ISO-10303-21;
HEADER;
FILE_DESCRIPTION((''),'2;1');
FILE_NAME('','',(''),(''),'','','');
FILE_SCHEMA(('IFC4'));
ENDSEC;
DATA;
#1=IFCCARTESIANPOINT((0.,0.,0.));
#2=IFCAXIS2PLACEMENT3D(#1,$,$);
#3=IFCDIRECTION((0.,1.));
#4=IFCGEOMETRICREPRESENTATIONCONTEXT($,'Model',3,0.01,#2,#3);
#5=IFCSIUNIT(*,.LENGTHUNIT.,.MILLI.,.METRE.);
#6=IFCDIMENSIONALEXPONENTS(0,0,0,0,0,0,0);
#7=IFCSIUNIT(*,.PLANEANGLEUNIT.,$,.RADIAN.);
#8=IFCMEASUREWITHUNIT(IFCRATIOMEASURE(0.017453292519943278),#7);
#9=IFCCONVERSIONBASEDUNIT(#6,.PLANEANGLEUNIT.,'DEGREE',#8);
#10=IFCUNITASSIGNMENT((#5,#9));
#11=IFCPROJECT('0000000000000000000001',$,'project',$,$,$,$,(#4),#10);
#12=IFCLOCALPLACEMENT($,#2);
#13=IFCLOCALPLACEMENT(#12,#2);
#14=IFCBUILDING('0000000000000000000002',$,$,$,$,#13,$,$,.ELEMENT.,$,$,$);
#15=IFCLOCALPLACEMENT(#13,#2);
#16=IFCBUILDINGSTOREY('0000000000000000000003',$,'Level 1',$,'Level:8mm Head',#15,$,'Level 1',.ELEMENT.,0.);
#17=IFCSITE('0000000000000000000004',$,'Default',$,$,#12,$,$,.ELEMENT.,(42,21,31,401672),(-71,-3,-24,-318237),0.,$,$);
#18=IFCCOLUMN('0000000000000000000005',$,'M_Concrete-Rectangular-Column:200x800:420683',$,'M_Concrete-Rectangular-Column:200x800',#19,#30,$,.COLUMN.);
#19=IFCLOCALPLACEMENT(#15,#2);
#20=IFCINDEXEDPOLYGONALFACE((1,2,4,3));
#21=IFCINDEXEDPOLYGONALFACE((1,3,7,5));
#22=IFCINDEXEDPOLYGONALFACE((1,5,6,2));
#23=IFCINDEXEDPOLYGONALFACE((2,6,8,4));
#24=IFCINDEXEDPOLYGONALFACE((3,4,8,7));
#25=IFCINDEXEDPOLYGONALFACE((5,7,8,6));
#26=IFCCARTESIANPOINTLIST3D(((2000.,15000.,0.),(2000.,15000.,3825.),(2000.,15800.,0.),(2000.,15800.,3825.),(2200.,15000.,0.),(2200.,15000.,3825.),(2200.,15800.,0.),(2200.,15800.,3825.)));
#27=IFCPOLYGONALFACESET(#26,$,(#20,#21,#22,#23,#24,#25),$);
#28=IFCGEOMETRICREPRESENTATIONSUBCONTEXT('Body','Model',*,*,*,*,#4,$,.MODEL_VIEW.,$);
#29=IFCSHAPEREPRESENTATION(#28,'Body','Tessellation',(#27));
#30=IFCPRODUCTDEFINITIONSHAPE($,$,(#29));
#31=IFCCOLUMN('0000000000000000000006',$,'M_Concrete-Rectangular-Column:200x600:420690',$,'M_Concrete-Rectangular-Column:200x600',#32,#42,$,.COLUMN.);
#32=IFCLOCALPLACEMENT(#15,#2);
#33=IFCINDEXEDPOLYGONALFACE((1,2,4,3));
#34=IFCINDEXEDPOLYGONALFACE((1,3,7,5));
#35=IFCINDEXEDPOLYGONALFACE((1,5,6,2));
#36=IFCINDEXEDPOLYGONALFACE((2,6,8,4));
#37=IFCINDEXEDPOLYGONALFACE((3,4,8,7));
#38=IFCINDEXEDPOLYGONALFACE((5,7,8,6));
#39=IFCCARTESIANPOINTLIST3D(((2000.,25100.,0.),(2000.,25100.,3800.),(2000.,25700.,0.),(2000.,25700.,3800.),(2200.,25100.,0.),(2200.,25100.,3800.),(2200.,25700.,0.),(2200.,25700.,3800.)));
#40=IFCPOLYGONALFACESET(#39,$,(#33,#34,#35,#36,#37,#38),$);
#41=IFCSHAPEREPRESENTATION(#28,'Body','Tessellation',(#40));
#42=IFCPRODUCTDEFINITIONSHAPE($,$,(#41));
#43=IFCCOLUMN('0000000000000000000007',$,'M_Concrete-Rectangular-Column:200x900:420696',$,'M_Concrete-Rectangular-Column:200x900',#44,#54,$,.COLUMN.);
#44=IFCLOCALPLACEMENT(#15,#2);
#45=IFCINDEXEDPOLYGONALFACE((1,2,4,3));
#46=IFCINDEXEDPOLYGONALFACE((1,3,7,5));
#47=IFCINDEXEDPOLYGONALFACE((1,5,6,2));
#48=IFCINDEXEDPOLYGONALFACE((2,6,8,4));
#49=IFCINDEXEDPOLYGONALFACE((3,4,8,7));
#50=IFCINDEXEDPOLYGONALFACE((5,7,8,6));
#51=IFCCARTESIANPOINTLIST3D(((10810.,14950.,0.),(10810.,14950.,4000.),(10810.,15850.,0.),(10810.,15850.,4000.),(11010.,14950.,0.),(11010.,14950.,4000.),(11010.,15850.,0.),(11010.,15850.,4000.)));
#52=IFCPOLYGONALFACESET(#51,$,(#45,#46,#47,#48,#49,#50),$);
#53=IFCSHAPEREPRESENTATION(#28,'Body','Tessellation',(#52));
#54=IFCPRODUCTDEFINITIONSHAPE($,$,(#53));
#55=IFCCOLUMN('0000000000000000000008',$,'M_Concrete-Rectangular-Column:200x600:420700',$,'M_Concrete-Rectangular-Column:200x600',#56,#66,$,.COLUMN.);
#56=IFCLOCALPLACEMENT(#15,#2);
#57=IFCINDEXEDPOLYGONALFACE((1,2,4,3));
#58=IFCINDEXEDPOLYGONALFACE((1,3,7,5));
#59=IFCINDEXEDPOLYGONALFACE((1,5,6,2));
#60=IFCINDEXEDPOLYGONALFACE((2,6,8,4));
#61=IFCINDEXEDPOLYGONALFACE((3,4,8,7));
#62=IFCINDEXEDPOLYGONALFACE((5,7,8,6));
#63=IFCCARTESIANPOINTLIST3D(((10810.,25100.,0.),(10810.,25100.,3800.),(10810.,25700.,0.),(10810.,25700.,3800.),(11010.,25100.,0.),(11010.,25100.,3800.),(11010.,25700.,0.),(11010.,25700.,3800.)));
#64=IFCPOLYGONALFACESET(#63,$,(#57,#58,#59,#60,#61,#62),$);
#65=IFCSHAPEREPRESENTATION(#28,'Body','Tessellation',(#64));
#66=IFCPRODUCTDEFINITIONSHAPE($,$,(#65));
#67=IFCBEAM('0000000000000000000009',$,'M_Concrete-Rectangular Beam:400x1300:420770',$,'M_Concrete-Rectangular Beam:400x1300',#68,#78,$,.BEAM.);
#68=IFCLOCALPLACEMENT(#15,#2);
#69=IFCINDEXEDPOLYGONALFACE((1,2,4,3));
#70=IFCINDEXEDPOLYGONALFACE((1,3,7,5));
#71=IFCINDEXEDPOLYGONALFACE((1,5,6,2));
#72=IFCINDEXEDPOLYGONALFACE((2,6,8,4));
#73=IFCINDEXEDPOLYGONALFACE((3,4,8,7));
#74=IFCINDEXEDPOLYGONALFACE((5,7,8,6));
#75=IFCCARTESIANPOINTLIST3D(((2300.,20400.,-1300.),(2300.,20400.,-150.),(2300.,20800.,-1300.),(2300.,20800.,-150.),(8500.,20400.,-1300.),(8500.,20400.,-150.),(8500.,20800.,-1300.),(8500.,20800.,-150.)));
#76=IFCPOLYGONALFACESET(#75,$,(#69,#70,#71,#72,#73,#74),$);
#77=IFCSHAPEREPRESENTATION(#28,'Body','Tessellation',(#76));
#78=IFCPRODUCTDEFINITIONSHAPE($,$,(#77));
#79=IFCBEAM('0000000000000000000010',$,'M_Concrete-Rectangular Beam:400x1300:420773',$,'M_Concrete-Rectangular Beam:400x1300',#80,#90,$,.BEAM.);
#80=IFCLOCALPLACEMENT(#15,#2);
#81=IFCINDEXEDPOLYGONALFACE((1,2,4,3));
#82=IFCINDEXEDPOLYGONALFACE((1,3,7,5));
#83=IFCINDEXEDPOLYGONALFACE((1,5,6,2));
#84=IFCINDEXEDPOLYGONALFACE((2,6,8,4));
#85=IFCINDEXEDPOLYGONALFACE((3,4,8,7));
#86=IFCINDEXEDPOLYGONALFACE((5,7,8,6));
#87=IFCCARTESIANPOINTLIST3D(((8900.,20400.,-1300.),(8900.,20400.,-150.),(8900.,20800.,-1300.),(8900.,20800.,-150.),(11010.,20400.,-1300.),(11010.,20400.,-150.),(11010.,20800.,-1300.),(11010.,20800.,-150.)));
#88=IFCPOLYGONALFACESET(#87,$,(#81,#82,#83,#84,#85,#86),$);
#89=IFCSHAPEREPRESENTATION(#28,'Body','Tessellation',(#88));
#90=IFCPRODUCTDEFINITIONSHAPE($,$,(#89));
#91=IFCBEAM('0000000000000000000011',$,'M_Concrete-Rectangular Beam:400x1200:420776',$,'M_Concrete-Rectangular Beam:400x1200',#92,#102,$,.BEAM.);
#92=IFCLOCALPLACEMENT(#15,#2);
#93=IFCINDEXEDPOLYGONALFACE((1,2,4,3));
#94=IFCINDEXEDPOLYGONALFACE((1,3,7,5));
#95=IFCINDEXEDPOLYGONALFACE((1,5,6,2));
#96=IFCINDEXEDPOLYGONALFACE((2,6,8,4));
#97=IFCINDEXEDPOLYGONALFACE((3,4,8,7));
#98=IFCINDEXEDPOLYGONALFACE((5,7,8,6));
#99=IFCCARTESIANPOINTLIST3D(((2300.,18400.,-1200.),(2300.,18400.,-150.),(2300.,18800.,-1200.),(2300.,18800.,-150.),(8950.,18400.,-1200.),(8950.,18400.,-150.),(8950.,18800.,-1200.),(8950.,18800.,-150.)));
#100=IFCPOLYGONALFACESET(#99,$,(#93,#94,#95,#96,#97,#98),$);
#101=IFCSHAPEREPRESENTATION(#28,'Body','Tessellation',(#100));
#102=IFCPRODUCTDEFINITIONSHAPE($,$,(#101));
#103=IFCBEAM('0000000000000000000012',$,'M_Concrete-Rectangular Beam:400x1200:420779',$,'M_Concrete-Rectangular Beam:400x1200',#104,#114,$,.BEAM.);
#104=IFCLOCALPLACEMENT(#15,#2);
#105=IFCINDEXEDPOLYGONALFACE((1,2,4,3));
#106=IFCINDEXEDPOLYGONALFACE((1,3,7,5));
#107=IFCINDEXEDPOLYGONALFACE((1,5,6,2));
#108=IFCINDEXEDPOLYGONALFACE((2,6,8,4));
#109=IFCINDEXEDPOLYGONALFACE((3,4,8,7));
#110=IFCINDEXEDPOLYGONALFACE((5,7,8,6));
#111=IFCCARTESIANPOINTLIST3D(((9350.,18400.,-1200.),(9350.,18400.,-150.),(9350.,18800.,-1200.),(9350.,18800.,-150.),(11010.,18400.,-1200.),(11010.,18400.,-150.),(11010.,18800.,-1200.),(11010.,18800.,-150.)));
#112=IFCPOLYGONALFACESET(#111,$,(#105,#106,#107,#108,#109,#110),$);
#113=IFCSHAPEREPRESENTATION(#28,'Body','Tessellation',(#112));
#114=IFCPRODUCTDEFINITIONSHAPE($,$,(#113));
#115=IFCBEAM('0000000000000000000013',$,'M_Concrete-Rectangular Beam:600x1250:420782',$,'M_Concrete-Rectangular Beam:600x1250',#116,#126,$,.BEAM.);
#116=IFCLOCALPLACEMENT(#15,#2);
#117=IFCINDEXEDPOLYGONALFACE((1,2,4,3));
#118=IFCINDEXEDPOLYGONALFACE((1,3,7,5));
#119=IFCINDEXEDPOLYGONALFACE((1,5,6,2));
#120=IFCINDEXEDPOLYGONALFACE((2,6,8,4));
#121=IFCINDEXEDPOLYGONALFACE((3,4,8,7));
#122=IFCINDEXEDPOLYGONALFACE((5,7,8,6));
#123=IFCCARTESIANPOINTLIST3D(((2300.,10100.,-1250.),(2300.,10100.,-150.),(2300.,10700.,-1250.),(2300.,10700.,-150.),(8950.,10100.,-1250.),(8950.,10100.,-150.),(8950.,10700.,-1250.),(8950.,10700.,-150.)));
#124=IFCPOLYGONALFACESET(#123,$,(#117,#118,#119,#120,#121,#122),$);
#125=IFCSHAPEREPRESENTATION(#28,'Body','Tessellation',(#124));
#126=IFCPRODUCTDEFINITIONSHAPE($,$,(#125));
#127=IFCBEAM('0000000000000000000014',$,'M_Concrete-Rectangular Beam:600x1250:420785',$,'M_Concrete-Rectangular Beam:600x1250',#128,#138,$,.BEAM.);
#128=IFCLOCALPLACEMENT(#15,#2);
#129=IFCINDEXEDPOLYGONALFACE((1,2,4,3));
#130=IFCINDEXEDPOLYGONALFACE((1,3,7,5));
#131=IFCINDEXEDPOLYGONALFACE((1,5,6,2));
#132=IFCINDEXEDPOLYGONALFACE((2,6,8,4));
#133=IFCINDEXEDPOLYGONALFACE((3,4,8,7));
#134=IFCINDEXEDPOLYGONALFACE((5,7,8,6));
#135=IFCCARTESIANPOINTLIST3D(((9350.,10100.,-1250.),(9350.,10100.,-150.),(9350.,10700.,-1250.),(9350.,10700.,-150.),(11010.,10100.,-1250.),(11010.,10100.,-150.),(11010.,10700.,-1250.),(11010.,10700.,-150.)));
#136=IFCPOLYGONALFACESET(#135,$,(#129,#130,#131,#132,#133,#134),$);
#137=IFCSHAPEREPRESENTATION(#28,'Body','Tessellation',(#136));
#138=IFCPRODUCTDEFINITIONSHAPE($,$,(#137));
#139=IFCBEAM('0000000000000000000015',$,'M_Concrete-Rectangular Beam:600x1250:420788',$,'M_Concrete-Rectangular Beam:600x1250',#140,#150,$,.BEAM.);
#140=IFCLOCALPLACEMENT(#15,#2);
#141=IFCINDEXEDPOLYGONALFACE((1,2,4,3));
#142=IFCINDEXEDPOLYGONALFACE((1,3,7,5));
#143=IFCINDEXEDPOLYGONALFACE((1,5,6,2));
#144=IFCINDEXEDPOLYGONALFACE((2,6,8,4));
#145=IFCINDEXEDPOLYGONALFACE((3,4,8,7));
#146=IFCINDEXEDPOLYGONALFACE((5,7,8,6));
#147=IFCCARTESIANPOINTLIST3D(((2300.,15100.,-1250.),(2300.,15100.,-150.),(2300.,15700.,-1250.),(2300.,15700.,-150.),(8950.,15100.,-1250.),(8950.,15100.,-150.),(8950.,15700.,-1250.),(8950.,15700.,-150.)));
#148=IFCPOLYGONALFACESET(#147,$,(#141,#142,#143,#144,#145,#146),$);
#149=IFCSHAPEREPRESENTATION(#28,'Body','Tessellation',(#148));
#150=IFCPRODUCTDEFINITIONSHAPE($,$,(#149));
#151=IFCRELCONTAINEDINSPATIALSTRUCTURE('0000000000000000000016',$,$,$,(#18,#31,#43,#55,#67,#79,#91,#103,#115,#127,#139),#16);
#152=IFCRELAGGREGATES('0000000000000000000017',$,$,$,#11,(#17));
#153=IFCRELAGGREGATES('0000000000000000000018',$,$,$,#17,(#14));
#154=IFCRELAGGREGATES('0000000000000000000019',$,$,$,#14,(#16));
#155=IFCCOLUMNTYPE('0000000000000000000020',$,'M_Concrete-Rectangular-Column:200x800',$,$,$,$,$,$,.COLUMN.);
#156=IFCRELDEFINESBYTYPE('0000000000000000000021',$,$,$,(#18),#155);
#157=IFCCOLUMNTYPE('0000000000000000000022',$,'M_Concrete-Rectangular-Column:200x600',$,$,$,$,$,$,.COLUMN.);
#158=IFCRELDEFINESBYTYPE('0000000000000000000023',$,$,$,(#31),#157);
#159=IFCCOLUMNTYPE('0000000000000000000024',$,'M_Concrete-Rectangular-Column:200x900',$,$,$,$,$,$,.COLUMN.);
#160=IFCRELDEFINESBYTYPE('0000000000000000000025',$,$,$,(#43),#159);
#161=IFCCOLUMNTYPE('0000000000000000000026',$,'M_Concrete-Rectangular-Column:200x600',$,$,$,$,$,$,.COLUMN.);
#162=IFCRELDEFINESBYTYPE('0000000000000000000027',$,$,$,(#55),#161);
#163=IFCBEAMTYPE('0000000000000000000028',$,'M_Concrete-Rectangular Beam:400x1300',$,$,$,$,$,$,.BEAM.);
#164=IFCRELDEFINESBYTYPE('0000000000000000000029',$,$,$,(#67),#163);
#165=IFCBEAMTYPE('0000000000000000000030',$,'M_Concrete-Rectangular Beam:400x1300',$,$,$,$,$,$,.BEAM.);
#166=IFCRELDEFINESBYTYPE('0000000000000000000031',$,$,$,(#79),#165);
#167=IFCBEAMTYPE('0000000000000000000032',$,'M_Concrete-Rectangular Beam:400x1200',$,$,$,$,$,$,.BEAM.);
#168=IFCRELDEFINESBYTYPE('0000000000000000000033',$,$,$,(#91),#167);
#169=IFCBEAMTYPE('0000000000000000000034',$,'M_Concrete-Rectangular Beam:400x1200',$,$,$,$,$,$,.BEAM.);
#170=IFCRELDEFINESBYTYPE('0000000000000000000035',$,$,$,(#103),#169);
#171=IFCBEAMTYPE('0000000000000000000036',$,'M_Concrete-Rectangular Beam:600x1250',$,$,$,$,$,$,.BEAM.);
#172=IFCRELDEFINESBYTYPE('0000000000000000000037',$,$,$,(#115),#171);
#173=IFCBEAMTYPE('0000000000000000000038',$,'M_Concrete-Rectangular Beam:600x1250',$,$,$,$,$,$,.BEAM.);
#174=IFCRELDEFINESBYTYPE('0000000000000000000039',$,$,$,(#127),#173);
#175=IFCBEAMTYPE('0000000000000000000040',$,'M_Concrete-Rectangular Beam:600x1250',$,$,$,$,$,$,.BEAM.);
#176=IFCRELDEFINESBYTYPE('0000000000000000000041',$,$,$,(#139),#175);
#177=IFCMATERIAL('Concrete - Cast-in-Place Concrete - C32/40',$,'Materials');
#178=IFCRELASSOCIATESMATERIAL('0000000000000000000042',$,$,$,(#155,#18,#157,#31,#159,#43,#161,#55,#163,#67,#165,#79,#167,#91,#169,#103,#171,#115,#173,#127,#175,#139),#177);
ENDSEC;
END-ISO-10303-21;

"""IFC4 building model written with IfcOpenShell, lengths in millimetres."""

from ifc_helpers import new_model, entity, si_unit, converted_unit, direction, frame, origin, place, context, subcontext, project, spatial, indexed_curve, outline, extrude, source, transform, mapped, material, type_object, type_shapes, element, save


model = new_model("IFC4")

# Units and contexts
model_context = context("Model", 3, precision=0.01, world=origin(), true_north=direction((0.0, 1.0)))
body_context = subcontext(model_context, "Body", "Model", "MODEL_VIEW")
ifc_project = project(units=[si_unit("LENGTHUNIT", "METRE", prefix="MILLI"), converted_unit("PLANEANGLEUNIT", "DEGREE", entity("IfcRatioMeasure", 0.017453292519943278), si_unit("PLANEANGLEUNIT", "RADIAN"), dimensions=[0, 0, 0, 0, 0, 0, 0])], contexts=[model_context])

# Site, building, storey
site_placement = place(None, origin())
site = spatial("IfcSite", under=ifc_project, at=site_placement, Name="Default", CompositionType="ELEMENT", RefLatitude=(42, 21, 31, 401672), RefLongitude=(-71, -3, -24, -318237), RefElevation=0.0)
building_placement = place(site_placement, origin())
building = spatial("IfcBuilding", under=site, at=building_placement, CompositionType="ELEMENT")
storey_placement = place(building_placement, origin())
storey = spatial("IfcBuildingStorey", under=building, at=storey_placement, Name="Level 1", ObjectType="Level:8mm Head", LongName="Level 1", CompositionType="ELEMENT", Elevation=0.0)

# Columns
ifc_material = material(Name="Concrete - Cast-in-Place Concrete - C32/40", Category="Materials")
column_type_1 = type_object("IfcColumnType", Name="M_Concrete-Rectangular-Column:200x800", PredefinedType="COLUMN", material=ifc_material)
shared_shape_1 = source(origin(), body_context, "Body", "SweptSolid", [
    extrude(outline(indexed_curve([(-400.0, -100.0), (400.0, -100.0), (400.0, 100.0), (-400.0, 100.0), (-400.0, -100.0)], self_intersect=False)), frame((2100.0, 15400.0, 0.0), z_axis=(0.0, 0.0, 1.0), x_axis=(0.0, -1.0, 0.0)), (0.0, 0.0, 1.0), 3825.0),
])
type_shapes(column_type_1, [shared_shape_1])
column_1_placement = place(storey_placement, origin())
element("IfcColumn", 1, at=column_1_placement, inside=storey, type_object=column_type_1, material=ifc_material, Name="M_Concrete-Rectangular-Column:200x800:420683", ObjectType="M_Concrete-Rectangular-Column:200x800", PredefinedType="COLUMN", context=body_context, shape_type="MappedRepresentation", body=[
    mapped(shared_shape_1, transform((0.0, 0.0, 0.0), scale=1.0)),
])
column_type_2 = type_object("IfcColumnType", Name="M_Concrete-Rectangular-Column:200x600", PredefinedType="COLUMN", material=ifc_material)
shared_shape_2 = source(origin(), body_context, "Body", "SweptSolid", [
    extrude(outline(indexed_curve([(-300.0, -100.0), (300.0, -100.0), (300.0, 100.0), (-300.0, 100.0), (-300.0, -100.0)], self_intersect=False)), frame((2100.0, 25400.0, 0.0), z_axis=(0.0, 0.0, 1.0), x_axis=(0.0, -1.0, 0.0)), (0.0, 0.0, 1.0), 3800.0),
])
type_shapes(column_type_2, [shared_shape_2])
column_2_placement = place(storey_placement, origin())
element("IfcColumn", 2, at=column_2_placement, inside=storey, type_object=column_type_2, material=ifc_material, Name="M_Concrete-Rectangular-Column:200x600:420690", ObjectType="M_Concrete-Rectangular-Column:200x600", PredefinedType="COLUMN", context=body_context, shape_type="MappedRepresentation", body=[
    mapped(shared_shape_2, transform((0.0, 0.0, 0.0), scale=1.0)),
])
column_type_3 = type_object("IfcColumnType", Name="M_Concrete-Rectangular-Column:200x900", PredefinedType="COLUMN", material=ifc_material)
shared_shape_3 = source(origin(), body_context, "Body", "SweptSolid", [
    extrude(outline(indexed_curve([(-450.0, -100.0), (450.0, -100.0), (450.0, 100.0), (-450.0, 100.0), (-450.0, -100.0)], self_intersect=False)), frame((10910.0, 15400.0, 0.0), z_axis=(0.0, 0.0, 1.0), x_axis=(0.0, -1.0, 0.0)), (0.0, 0.0, 1.0), 4000.0),
])
type_shapes(column_type_3, [shared_shape_3])
column_3_placement = place(storey_placement, origin())
element("IfcColumn", 3, at=column_3_placement, inside=storey, type_object=column_type_3, material=ifc_material, Name="M_Concrete-Rectangular-Column:200x900:420696", ObjectType="M_Concrete-Rectangular-Column:200x900", PredefinedType="COLUMN", context=body_context, shape_type="MappedRepresentation", body=[
    mapped(shared_shape_3, transform((0.0, 0.0, 0.0), scale=1.0)),
])
column_type_4 = type_object("IfcColumnType", Name="M_Concrete-Rectangular-Column:200x600", PredefinedType="COLUMN", material=ifc_material)
shared_shape_4 = source(origin(), body_context, "Body", "SweptSolid", [
    extrude(outline(indexed_curve([(-300.0, -100.0), (300.0, -100.0), (300.0, 100.0), (-300.0, 100.0), (-300.0, -100.0)], self_intersect=False)), frame((10910.0, 25400.0, 0.0), z_axis=(0.0, 0.0, 1.0), x_axis=(0.0, -1.0, 0.0)), (0.0, 0.0, 1.0), 3800.0),
])
type_shapes(column_type_4, [shared_shape_4])
column_4_placement = place(storey_placement, origin())
element("IfcColumn", 4, at=column_4_placement, inside=storey, type_object=column_type_4, material=ifc_material, Name="M_Concrete-Rectangular-Column:200x600:420700", ObjectType="M_Concrete-Rectangular-Column:200x600", PredefinedType="COLUMN", context=body_context, shape_type="MappedRepresentation", body=[
    mapped(shared_shape_4, transform((0.0, 0.0, 0.0), scale=1.0)),
])

# Beams
beam_type_1 = type_object("IfcBeamType", Name="M_Concrete-Rectangular Beam:400x1300", PredefinedType="BEAM", material=ifc_material)
shared_shape_5 = source(origin(), body_context, "Body", "SweptSolid", [
    extrude(outline(indexed_curve([(-575.0, -200.0), (575.0, -200.0), (575.0, 200.0), (-575.0, 200.0), (-575.0, -200.0)], self_intersect=False)), frame((2300.0, 20600.0, -725.0), z_axis=(1.0, 0.0, 0.0), x_axis=(0.0, 0.0, -1.0)), (0.0, 0.0, 1.0), 6200.0),
])
type_shapes(beam_type_1, [shared_shape_5])
beam_1_placement = place(storey_placement, origin())
element("IfcBeam", 5, at=beam_1_placement, inside=storey, type_object=beam_type_1, material=ifc_material, Name="M_Concrete-Rectangular Beam:400x1300:420770", ObjectType="M_Concrete-Rectangular Beam:400x1300", PredefinedType="BEAM", context=body_context, shape_type="MappedRepresentation", body=[
    mapped(shared_shape_5, transform((0.0, 0.0, 0.0), scale=1.0)),
])
beam_type_2 = type_object("IfcBeamType", Name="M_Concrete-Rectangular Beam:400x1300", PredefinedType="BEAM", material=ifc_material)
shared_shape_6 = source(origin(), body_context, "Body", "SweptSolid", [
    extrude(outline(indexed_curve([(-575.0, -200.0), (575.0, -200.0), (575.0, 200.0), (-575.0, 200.0), (-575.0, -200.0)], self_intersect=False)), frame((8900.0, 20600.0, -725.0), z_axis=(1.0, 0.0, 0.0), x_axis=(0.0, 0.0, -1.0)), (0.0, 0.0, 1.0), 2110.0),
])
type_shapes(beam_type_2, [shared_shape_6])
beam_2_placement = place(storey_placement, origin())
element("IfcBeam", 6, at=beam_2_placement, inside=storey, type_object=beam_type_2, material=ifc_material, Name="M_Concrete-Rectangular Beam:400x1300:420773", ObjectType="M_Concrete-Rectangular Beam:400x1300", PredefinedType="BEAM", context=body_context, shape_type="MappedRepresentation", body=[
    mapped(shared_shape_6, transform((0.0, 0.0, 0.0), scale=1.0)),
])
beam_type_3 = type_object("IfcBeamType", Name="M_Concrete-Rectangular Beam:400x1200", PredefinedType="BEAM", material=ifc_material)
shared_shape_7 = source(origin(), body_context, "Body", "SweptSolid", [
    extrude(outline(indexed_curve([(-525.0, -200.0), (525.0, -200.0), (525.0, 200.0), (-525.0, 200.0), (-525.0, -200.0)], self_intersect=False)), frame((2300.0, 18600.0, -675.0), z_axis=(1.0, 0.0, 0.0), x_axis=(0.0, 0.0, -1.0)), (0.0, 0.0, 1.0), 6650.0),
])
type_shapes(beam_type_3, [shared_shape_7])
beam_3_placement = place(storey_placement, origin())
element("IfcBeam", 7, at=beam_3_placement, inside=storey, type_object=beam_type_3, material=ifc_material, Name="M_Concrete-Rectangular Beam:400x1200:420776", ObjectType="M_Concrete-Rectangular Beam:400x1200", PredefinedType="BEAM", context=body_context, shape_type="MappedRepresentation", body=[
    mapped(shared_shape_7, transform((0.0, 0.0, 0.0), scale=1.0)),
])
beam_type_4 = type_object("IfcBeamType", Name="M_Concrete-Rectangular Beam:400x1200", PredefinedType="BEAM", material=ifc_material)
shared_shape_8 = source(origin(), body_context, "Body", "SweptSolid", [
    extrude(outline(indexed_curve([(-525.0, -200.0), (525.0, -200.0), (525.0, 200.0), (-525.0, 200.0), (-525.0, -200.0)], self_intersect=False)), frame((9350.0, 18600.0, -675.0), z_axis=(1.0, 0.0, 0.0), x_axis=(0.0, 0.0, -1.0)), (0.0, 0.0, 1.0), 1660.0),
])
type_shapes(beam_type_4, [shared_shape_8])
beam_4_placement = place(storey_placement, origin())
element("IfcBeam", 8, at=beam_4_placement, inside=storey, type_object=beam_type_4, material=ifc_material, Name="M_Concrete-Rectangular Beam:400x1200:420779", ObjectType="M_Concrete-Rectangular Beam:400x1200", PredefinedType="BEAM", context=body_context, shape_type="MappedRepresentation", body=[
    mapped(shared_shape_8, transform((0.0, 0.0, 0.0), scale=1.0)),
])
beam_type_5 = type_object("IfcBeamType", Name="M_Concrete-Rectangular Beam:600x1250", PredefinedType="BEAM", material=ifc_material)
shared_shape_9 = source(origin(), body_context, "Body", "SweptSolid", [
    extrude(outline(indexed_curve([(-550.0, -300.0), (550.0, -300.0), (550.0, 300.0), (-550.0, 300.0), (-550.0, -300.0)], self_intersect=False)), frame((2300.0, 10400.0, -700.0), z_axis=(1.0, 0.0, 0.0), x_axis=(0.0, 0.0, -1.0)), (0.0, 0.0, 1.0), 6650.0),
])
type_shapes(beam_type_5, [shared_shape_9])
beam_5_placement = place(storey_placement, origin())
element("IfcBeam", 9, at=beam_5_placement, inside=storey, type_object=beam_type_5, material=ifc_material, Name="M_Concrete-Rectangular Beam:600x1250:420782", ObjectType="M_Concrete-Rectangular Beam:600x1250", PredefinedType="BEAM", context=body_context, shape_type="MappedRepresentation", body=[
    mapped(shared_shape_9, transform((0.0, 0.0, 0.0), scale=1.0)),
])
beam_type_6 = type_object("IfcBeamType", Name="M_Concrete-Rectangular Beam:600x1250", PredefinedType="BEAM", material=ifc_material)
shared_shape_10 = source(origin(), body_context, "Body", "SweptSolid", [
    extrude(outline(indexed_curve([(-550.0, -300.0), (550.0, -300.0), (550.0, 300.0), (-550.0, 300.0), (-550.0, -300.0)], self_intersect=False)), frame((9350.0, 10400.0, -700.0), z_axis=(1.0, 0.0, 0.0), x_axis=(0.0, 0.0, -1.0)), (0.0, 0.0, 1.0), 1660.0),
])
type_shapes(beam_type_6, [shared_shape_10])
beam_6_placement = place(storey_placement, origin())
element("IfcBeam", 10, at=beam_6_placement, inside=storey, type_object=beam_type_6, material=ifc_material, Name="M_Concrete-Rectangular Beam:600x1250:420785", ObjectType="M_Concrete-Rectangular Beam:600x1250", PredefinedType="BEAM", context=body_context, shape_type="MappedRepresentation", body=[
    mapped(shared_shape_10, transform((0.0, 0.0, 0.0), scale=1.0)),
])
beam_type_7 = type_object("IfcBeamType", Name="M_Concrete-Rectangular Beam:600x1250", PredefinedType="BEAM", material=ifc_material)
shared_shape_11 = source(origin(), body_context, "Body", "SweptSolid", [
    extrude(outline(indexed_curve([(-550.0, -300.0), (550.0, -300.0), (550.0, 300.0), (-550.0, 300.0), (-550.0, -300.0)], self_intersect=False)), frame((2300.0, 15400.0, -700.0), z_axis=(1.0, 0.0, 0.0), x_axis=(0.0, 0.0, -1.0)), (0.0, 0.0, 1.0), 6650.0),
])
type_shapes(beam_type_7, [shared_shape_11])
beam_7_placement = place(storey_placement, origin())
element("IfcBeam", 11, at=beam_7_placement, inside=storey, type_object=beam_type_7, material=ifc_material, Name="M_Concrete-Rectangular Beam:600x1250:420788", ObjectType="M_Concrete-Rectangular Beam:600x1250", PredefinedType="BEAM", context=body_context, shape_type="MappedRepresentation", body=[
    mapped(shared_shape_11, transform((0.0, 0.0, 0.0), scale=1.0)),
])

save(model, "model.ifc")
